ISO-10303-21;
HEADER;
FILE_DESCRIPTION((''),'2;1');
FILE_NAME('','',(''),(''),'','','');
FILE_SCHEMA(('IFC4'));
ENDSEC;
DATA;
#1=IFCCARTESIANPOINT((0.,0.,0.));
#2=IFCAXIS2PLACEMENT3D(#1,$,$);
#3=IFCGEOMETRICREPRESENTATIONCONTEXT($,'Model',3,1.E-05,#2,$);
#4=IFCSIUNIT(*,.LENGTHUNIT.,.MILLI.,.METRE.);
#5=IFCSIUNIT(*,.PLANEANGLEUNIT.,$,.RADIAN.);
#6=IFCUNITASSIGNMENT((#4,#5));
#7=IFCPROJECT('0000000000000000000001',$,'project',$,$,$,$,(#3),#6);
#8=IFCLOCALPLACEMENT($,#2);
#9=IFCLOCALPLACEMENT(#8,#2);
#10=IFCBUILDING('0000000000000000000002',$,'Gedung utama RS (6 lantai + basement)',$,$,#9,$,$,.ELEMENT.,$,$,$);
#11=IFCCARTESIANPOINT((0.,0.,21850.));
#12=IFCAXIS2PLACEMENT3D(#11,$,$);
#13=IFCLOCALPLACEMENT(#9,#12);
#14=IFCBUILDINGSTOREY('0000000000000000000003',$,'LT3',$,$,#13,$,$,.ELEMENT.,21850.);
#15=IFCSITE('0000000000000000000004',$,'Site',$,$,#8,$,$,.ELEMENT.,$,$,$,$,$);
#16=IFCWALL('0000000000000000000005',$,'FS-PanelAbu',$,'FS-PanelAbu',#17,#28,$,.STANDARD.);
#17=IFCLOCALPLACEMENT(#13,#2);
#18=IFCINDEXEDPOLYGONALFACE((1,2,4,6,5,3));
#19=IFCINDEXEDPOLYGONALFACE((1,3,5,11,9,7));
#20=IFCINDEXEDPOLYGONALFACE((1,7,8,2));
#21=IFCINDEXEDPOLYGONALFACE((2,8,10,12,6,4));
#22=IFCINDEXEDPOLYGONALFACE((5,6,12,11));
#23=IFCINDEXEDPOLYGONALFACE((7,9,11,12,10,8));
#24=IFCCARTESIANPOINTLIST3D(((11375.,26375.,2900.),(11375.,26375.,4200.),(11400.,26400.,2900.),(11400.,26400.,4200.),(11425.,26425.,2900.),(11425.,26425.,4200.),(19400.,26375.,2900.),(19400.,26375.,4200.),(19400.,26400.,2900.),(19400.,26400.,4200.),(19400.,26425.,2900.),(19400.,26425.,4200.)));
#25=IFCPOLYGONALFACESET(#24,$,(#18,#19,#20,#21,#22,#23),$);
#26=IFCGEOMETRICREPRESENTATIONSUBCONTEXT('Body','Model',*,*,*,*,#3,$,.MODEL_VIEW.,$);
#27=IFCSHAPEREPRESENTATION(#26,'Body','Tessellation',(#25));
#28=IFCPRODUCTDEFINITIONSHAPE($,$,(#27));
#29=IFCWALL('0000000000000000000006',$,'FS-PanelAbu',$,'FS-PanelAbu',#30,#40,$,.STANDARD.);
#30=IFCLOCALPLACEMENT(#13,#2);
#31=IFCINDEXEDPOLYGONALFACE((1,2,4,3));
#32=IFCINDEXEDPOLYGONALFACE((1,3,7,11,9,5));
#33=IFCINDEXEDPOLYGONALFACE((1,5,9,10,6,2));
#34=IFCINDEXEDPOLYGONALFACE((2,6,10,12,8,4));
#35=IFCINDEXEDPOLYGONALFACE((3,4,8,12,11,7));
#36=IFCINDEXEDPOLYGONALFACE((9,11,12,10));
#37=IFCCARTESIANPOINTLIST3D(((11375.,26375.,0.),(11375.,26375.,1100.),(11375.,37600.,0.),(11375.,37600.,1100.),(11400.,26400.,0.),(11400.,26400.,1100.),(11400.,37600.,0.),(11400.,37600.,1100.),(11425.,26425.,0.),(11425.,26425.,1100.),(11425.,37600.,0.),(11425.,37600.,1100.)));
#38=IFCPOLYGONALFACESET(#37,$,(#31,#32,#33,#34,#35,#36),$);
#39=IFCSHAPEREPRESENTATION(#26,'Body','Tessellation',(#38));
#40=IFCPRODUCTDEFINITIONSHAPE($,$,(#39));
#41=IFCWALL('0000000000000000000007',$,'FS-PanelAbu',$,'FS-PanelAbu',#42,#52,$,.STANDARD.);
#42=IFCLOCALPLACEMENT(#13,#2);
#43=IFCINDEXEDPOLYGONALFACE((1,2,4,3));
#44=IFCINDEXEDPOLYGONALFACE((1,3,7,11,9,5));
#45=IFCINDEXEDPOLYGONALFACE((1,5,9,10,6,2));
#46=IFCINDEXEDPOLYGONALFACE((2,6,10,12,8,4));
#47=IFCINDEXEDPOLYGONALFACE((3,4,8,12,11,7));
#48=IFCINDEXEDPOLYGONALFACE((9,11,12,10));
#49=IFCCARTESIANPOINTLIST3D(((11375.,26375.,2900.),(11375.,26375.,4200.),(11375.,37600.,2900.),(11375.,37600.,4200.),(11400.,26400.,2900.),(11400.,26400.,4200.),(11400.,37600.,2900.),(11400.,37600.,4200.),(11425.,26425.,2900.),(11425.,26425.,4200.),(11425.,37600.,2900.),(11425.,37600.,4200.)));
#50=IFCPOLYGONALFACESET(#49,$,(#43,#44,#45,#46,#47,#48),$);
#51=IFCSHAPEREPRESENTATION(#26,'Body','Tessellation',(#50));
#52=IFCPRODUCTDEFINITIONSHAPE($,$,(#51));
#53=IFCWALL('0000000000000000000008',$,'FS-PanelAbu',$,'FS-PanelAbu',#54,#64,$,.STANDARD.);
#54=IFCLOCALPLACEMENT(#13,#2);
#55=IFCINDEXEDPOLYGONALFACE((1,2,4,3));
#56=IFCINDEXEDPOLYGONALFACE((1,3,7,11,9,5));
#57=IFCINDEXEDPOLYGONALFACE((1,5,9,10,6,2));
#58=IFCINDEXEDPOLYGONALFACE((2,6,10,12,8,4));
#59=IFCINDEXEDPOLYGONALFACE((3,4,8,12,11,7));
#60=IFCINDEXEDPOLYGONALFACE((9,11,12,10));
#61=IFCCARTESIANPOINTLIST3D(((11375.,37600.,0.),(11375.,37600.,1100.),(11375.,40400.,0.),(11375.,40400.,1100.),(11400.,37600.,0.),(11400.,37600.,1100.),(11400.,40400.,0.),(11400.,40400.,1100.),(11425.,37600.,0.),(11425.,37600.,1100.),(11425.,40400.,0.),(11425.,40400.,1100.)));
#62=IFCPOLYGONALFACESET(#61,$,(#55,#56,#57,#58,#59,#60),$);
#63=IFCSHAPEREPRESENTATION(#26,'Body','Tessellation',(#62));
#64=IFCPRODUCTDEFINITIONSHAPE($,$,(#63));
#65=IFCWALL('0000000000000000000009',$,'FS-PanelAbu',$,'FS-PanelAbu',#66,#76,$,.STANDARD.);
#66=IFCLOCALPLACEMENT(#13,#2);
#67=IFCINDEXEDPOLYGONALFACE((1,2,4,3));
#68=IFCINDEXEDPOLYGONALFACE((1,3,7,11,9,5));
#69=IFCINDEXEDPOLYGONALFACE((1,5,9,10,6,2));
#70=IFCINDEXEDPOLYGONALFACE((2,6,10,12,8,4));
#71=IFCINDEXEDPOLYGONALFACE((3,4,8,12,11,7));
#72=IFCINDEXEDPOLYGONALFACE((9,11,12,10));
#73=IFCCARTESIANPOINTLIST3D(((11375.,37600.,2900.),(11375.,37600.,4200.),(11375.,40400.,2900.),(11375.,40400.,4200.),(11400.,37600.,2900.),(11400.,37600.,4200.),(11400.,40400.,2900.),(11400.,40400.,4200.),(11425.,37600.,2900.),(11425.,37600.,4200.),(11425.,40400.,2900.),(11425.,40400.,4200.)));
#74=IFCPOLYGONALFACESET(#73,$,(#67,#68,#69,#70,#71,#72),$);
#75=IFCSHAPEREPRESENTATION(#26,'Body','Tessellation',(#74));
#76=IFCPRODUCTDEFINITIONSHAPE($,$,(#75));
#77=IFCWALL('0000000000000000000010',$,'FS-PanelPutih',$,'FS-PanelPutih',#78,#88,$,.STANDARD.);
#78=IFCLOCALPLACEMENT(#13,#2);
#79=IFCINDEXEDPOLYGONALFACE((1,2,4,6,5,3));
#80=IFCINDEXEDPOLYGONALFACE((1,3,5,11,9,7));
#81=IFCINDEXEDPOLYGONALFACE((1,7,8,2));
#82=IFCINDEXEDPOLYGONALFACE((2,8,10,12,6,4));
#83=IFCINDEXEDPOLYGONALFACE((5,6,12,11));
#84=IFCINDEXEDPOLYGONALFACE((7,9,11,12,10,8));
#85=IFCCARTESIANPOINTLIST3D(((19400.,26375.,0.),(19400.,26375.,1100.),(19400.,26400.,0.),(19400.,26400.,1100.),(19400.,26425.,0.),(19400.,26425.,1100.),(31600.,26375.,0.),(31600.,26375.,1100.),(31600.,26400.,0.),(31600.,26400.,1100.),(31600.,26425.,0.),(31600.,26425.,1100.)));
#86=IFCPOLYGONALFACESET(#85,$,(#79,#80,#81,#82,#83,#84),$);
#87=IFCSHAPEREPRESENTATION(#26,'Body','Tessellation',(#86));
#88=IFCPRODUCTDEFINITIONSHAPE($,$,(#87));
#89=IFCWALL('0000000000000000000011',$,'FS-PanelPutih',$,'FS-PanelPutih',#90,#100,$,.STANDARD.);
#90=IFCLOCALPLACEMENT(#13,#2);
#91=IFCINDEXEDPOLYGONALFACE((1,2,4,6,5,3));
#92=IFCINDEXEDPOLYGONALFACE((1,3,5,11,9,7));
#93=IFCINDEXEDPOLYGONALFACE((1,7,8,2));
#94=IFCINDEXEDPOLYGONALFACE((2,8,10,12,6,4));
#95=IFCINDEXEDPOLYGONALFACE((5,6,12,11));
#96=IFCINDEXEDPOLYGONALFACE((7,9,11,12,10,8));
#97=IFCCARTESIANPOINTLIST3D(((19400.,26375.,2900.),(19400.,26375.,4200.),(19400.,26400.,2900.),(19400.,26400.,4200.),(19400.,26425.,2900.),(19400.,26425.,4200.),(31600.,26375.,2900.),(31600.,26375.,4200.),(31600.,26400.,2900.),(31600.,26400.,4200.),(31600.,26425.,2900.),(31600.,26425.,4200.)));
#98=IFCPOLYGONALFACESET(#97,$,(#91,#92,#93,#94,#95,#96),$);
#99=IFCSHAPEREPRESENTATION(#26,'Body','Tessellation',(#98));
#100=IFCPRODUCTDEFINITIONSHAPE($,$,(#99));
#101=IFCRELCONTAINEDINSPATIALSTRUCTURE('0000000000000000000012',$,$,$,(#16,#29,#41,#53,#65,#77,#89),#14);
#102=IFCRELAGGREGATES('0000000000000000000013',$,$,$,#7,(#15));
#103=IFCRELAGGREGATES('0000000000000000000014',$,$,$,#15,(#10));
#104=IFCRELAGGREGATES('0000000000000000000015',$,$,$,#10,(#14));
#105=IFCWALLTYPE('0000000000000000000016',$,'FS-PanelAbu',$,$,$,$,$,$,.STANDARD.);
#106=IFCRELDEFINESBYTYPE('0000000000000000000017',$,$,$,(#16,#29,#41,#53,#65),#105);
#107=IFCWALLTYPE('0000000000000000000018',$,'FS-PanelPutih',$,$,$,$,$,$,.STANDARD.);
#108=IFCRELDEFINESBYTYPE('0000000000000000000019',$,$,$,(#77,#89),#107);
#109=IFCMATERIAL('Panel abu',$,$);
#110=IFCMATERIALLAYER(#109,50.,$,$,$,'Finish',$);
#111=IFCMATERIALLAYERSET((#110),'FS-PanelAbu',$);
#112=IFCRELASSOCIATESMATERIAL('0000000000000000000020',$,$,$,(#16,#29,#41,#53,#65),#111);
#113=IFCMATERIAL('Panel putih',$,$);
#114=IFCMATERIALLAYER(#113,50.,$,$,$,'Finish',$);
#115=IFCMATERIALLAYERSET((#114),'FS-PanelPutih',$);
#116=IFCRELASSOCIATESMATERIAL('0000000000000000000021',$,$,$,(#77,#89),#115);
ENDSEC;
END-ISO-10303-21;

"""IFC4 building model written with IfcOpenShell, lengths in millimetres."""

from ifc_helpers import new_model, si_unit, frame, origin, place, context, subcontext, project, spatial, polyline, outline, extrude, material, layer, layer_set, layer_usage, type_object, element, save


model = new_model("IFC4")

# Units and contexts
model_context = context("Model", 3, precision=1e-05, world=origin())
body_context = subcontext(model_context, "Body", "Model", "MODEL_VIEW")
ifc_project = project(units=[si_unit("LENGTHUNIT", "METRE", prefix="MILLI"), si_unit("PLANEANGLEUNIT", "RADIAN")], contexts=[model_context])

# Site, building, storey
site_placement = place(None, origin())
site = spatial("IfcSite", under=ifc_project, at=site_placement, Name="Site", CompositionType="ELEMENT")
building_placement = place(site_placement, origin())
building = spatial("IfcBuilding", under=site, at=building_placement, Name="Gedung utama RS (6 lantai + basement)", CompositionType="ELEMENT")
storey_placement = place(building_placement, frame((0.0, 0.0, 21850.0)))
storey = spatial("IfcBuildingStorey", under=building, at=storey_placement, Name="LT3", CompositionType="ELEMENT", Elevation=21850.0)

# Walls
ifc_material_1 = material(Name="Panel abu")
ifc_layer_1 = layer(ifc_material_1, 50.0, Category="Finish")
ifc_layer_set_1 = layer_set([ifc_layer_1], Name="FS-PanelAbu")
ifc_layer_usage_1 = layer_usage(ifc_layer_set_1, "AXIS2", "NEGATIVE", 25.0)
wall_type_1 = type_object("IfcWallType", Name="FS-PanelAbu", PredefinedType="STANDARD")
wall_1_placement = place(storey_placement, frame((19400.0, 26400.0, 2900.0), z_axis=(0.0, 0.0, 1.0), x_axis=(-1.0, 0.0, 0.0)))
element("IfcWall", 1, at=wall_1_placement, inside=storey, type_object=wall_type_1, material=ifc_layer_usage_1, Name="FS-PanelAbu", ObjectType="FS-PanelAbu", PredefinedType="STANDARD", context=body_context, shape_type="SweptSolid", body=[
    extrude(outline(polyline([(0.0, -25.0), (0.0, 0.0), (0.0, 25.0), (8025.0, 25.0), (8000.0, 0.0), (7975.0, -25.0), (0.0, -25.0)])), origin(), (0.0, 0.0, 1.0), 1300.0),
])
wall_2_placement = place(storey_placement, frame((11400.0, 26400.0, 0.0), z_axis=(0.0, 0.0, 1.0), x_axis=(0.0, 1.0, 0.0)))
element("IfcWall", 2, at=wall_2_placement, inside=storey, type_object=wall_type_1, material=ifc_layer_usage_1, Name="FS-PanelAbu", ObjectType="FS-PanelAbu", PredefinedType="STANDARD", context=body_context, shape_type="SweptSolid", body=[
    extrude(outline(polyline([(25.0, -25.0), (0.0, 0.0), (-25.0, 25.0), (11200.0, 25.0), (11200.0, 0.0), (11200.0, -25.0), (25.0, -25.0)])), origin(), (0.0, 0.0, 1.0), 1100.0),
])
wall_3_placement = place(storey_placement, frame((11400.0, 26400.0, 2900.0), z_axis=(0.0, 0.0, 1.0), x_axis=(0.0, 1.0, 0.0)))
element("IfcWall", 3, at=wall_3_placement, inside=storey, type_object=wall_type_1, material=ifc_layer_usage_1, Name="FS-PanelAbu", ObjectType="FS-PanelAbu", PredefinedType="STANDARD", context=body_context, shape_type="SweptSolid", body=[
    extrude(outline(polyline([(25.0, -25.0), (0.0, 0.0), (-25.0, 25.0), (11200.0, 25.0), (11200.0, 0.0), (11200.0, -25.0), (25.0, -25.0)])), origin(), (0.0, 0.0, 1.0), 1300.0),
])
wall_4_placement = place(storey_placement, frame((11400.0, 37600.0, 0.0), z_axis=(0.0, 0.0, 1.0), x_axis=(0.0, 1.0, 0.0)))
element("IfcWall", 4, at=wall_4_placement, inside=storey, type_object=wall_type_1, material=ifc_layer_usage_1, Name="FS-PanelAbu", ObjectType="FS-PanelAbu", PredefinedType="STANDARD", context=body_context, shape_type="SweptSolid", body=[
    extrude(outline(polyline([(0.0, -25.0), (0.0, 0.0), (0.0, 25.0), (2800.0, 25.0), (2800.0, 0.0), (2800.0, -25.0), (0.0, -25.0)])), origin(), (0.0, 0.0, 1.0), 1100.0),
])
wall_5_placement = place(storey_placement, frame((11400.0, 37600.0, 2900.0), z_axis=(0.0, 0.0, 1.0), x_axis=(0.0, 1.0, 0.0)))
element("IfcWall", 5, at=wall_5_placement, inside=storey, type_object=wall_type_1, material=ifc_layer_usage_1, Name="FS-PanelAbu", ObjectType="FS-PanelAbu", PredefinedType="STANDARD", context=body_context, shape_type="SweptSolid", body=[
    extrude(outline(polyline([(0.0, -25.0), (0.0, 0.0), (0.0, 25.0), (2800.0, 25.0), (2800.0, 0.0), (2800.0, -25.0), (0.0, -25.0)])), origin(), (0.0, 0.0, 1.0), 1300.0),
])
ifc_material_2 = material(Name="Panel putih")
ifc_layer_2 = layer(ifc_material_2, 50.0, Category="Finish")
ifc_layer_set_2 = layer_set([ifc_layer_2], Name="FS-PanelPutih")
ifc_layer_usage_2 = layer_usage(ifc_layer_set_2, "AXIS2", "NEGATIVE", 25.0)
wall_type_2 = type_object("IfcWallType", Name="FS-PanelPutih", PredefinedType="STANDARD")
wall_6_placement = place(storey_placement, frame((31600.0, 26400.0, 0.0), z_axis=(0.0, 0.0, 1.0), x_axis=(-1.0, 0.0, 0.0)))
element("IfcWall", 6, at=wall_6_placement, inside=storey, type_object=wall_type_2, material=ifc_layer_usage_2, Name="FS-PanelPutih", ObjectType="FS-PanelPutih", PredefinedType="STANDARD", context=body_context, shape_type="SweptSolid", body=[
    extrude(outline(polyline([(0.0, -25.0), (0.0, 0.0), (0.0, 25.0), (12200.0, 25.0), (12200.0, 0.0), (12200.0, -25.0), (0.0, -25.0)])), origin(), (0.0, 0.0, 1.0), 1100.0),
])
wall_7_placement = place(storey_placement, frame((31600.0, 26400.0, 2900.0), z_axis=(0.0, 0.0, 1.0), x_axis=(-1.0, 0.0, 0.0)))
element("IfcWall", 7, at=wall_7_placement, inside=storey, type_object=wall_type_2, material=ifc_layer_usage_2, Name="FS-PanelPutih", ObjectType="FS-PanelPutih", PredefinedType="STANDARD", context=body_context, shape_type="SweptSolid", body=[
    extrude(outline(polyline([(0.0, -25.0), (0.0, 0.0), (0.0, 25.0), (12200.0, 25.0), (12200.0, 0.0), (12200.0, -25.0), (0.0, -25.0)])), origin(), (0.0, 0.0, 1.0), 1300.0),
])

save(model, "model.ifc")
